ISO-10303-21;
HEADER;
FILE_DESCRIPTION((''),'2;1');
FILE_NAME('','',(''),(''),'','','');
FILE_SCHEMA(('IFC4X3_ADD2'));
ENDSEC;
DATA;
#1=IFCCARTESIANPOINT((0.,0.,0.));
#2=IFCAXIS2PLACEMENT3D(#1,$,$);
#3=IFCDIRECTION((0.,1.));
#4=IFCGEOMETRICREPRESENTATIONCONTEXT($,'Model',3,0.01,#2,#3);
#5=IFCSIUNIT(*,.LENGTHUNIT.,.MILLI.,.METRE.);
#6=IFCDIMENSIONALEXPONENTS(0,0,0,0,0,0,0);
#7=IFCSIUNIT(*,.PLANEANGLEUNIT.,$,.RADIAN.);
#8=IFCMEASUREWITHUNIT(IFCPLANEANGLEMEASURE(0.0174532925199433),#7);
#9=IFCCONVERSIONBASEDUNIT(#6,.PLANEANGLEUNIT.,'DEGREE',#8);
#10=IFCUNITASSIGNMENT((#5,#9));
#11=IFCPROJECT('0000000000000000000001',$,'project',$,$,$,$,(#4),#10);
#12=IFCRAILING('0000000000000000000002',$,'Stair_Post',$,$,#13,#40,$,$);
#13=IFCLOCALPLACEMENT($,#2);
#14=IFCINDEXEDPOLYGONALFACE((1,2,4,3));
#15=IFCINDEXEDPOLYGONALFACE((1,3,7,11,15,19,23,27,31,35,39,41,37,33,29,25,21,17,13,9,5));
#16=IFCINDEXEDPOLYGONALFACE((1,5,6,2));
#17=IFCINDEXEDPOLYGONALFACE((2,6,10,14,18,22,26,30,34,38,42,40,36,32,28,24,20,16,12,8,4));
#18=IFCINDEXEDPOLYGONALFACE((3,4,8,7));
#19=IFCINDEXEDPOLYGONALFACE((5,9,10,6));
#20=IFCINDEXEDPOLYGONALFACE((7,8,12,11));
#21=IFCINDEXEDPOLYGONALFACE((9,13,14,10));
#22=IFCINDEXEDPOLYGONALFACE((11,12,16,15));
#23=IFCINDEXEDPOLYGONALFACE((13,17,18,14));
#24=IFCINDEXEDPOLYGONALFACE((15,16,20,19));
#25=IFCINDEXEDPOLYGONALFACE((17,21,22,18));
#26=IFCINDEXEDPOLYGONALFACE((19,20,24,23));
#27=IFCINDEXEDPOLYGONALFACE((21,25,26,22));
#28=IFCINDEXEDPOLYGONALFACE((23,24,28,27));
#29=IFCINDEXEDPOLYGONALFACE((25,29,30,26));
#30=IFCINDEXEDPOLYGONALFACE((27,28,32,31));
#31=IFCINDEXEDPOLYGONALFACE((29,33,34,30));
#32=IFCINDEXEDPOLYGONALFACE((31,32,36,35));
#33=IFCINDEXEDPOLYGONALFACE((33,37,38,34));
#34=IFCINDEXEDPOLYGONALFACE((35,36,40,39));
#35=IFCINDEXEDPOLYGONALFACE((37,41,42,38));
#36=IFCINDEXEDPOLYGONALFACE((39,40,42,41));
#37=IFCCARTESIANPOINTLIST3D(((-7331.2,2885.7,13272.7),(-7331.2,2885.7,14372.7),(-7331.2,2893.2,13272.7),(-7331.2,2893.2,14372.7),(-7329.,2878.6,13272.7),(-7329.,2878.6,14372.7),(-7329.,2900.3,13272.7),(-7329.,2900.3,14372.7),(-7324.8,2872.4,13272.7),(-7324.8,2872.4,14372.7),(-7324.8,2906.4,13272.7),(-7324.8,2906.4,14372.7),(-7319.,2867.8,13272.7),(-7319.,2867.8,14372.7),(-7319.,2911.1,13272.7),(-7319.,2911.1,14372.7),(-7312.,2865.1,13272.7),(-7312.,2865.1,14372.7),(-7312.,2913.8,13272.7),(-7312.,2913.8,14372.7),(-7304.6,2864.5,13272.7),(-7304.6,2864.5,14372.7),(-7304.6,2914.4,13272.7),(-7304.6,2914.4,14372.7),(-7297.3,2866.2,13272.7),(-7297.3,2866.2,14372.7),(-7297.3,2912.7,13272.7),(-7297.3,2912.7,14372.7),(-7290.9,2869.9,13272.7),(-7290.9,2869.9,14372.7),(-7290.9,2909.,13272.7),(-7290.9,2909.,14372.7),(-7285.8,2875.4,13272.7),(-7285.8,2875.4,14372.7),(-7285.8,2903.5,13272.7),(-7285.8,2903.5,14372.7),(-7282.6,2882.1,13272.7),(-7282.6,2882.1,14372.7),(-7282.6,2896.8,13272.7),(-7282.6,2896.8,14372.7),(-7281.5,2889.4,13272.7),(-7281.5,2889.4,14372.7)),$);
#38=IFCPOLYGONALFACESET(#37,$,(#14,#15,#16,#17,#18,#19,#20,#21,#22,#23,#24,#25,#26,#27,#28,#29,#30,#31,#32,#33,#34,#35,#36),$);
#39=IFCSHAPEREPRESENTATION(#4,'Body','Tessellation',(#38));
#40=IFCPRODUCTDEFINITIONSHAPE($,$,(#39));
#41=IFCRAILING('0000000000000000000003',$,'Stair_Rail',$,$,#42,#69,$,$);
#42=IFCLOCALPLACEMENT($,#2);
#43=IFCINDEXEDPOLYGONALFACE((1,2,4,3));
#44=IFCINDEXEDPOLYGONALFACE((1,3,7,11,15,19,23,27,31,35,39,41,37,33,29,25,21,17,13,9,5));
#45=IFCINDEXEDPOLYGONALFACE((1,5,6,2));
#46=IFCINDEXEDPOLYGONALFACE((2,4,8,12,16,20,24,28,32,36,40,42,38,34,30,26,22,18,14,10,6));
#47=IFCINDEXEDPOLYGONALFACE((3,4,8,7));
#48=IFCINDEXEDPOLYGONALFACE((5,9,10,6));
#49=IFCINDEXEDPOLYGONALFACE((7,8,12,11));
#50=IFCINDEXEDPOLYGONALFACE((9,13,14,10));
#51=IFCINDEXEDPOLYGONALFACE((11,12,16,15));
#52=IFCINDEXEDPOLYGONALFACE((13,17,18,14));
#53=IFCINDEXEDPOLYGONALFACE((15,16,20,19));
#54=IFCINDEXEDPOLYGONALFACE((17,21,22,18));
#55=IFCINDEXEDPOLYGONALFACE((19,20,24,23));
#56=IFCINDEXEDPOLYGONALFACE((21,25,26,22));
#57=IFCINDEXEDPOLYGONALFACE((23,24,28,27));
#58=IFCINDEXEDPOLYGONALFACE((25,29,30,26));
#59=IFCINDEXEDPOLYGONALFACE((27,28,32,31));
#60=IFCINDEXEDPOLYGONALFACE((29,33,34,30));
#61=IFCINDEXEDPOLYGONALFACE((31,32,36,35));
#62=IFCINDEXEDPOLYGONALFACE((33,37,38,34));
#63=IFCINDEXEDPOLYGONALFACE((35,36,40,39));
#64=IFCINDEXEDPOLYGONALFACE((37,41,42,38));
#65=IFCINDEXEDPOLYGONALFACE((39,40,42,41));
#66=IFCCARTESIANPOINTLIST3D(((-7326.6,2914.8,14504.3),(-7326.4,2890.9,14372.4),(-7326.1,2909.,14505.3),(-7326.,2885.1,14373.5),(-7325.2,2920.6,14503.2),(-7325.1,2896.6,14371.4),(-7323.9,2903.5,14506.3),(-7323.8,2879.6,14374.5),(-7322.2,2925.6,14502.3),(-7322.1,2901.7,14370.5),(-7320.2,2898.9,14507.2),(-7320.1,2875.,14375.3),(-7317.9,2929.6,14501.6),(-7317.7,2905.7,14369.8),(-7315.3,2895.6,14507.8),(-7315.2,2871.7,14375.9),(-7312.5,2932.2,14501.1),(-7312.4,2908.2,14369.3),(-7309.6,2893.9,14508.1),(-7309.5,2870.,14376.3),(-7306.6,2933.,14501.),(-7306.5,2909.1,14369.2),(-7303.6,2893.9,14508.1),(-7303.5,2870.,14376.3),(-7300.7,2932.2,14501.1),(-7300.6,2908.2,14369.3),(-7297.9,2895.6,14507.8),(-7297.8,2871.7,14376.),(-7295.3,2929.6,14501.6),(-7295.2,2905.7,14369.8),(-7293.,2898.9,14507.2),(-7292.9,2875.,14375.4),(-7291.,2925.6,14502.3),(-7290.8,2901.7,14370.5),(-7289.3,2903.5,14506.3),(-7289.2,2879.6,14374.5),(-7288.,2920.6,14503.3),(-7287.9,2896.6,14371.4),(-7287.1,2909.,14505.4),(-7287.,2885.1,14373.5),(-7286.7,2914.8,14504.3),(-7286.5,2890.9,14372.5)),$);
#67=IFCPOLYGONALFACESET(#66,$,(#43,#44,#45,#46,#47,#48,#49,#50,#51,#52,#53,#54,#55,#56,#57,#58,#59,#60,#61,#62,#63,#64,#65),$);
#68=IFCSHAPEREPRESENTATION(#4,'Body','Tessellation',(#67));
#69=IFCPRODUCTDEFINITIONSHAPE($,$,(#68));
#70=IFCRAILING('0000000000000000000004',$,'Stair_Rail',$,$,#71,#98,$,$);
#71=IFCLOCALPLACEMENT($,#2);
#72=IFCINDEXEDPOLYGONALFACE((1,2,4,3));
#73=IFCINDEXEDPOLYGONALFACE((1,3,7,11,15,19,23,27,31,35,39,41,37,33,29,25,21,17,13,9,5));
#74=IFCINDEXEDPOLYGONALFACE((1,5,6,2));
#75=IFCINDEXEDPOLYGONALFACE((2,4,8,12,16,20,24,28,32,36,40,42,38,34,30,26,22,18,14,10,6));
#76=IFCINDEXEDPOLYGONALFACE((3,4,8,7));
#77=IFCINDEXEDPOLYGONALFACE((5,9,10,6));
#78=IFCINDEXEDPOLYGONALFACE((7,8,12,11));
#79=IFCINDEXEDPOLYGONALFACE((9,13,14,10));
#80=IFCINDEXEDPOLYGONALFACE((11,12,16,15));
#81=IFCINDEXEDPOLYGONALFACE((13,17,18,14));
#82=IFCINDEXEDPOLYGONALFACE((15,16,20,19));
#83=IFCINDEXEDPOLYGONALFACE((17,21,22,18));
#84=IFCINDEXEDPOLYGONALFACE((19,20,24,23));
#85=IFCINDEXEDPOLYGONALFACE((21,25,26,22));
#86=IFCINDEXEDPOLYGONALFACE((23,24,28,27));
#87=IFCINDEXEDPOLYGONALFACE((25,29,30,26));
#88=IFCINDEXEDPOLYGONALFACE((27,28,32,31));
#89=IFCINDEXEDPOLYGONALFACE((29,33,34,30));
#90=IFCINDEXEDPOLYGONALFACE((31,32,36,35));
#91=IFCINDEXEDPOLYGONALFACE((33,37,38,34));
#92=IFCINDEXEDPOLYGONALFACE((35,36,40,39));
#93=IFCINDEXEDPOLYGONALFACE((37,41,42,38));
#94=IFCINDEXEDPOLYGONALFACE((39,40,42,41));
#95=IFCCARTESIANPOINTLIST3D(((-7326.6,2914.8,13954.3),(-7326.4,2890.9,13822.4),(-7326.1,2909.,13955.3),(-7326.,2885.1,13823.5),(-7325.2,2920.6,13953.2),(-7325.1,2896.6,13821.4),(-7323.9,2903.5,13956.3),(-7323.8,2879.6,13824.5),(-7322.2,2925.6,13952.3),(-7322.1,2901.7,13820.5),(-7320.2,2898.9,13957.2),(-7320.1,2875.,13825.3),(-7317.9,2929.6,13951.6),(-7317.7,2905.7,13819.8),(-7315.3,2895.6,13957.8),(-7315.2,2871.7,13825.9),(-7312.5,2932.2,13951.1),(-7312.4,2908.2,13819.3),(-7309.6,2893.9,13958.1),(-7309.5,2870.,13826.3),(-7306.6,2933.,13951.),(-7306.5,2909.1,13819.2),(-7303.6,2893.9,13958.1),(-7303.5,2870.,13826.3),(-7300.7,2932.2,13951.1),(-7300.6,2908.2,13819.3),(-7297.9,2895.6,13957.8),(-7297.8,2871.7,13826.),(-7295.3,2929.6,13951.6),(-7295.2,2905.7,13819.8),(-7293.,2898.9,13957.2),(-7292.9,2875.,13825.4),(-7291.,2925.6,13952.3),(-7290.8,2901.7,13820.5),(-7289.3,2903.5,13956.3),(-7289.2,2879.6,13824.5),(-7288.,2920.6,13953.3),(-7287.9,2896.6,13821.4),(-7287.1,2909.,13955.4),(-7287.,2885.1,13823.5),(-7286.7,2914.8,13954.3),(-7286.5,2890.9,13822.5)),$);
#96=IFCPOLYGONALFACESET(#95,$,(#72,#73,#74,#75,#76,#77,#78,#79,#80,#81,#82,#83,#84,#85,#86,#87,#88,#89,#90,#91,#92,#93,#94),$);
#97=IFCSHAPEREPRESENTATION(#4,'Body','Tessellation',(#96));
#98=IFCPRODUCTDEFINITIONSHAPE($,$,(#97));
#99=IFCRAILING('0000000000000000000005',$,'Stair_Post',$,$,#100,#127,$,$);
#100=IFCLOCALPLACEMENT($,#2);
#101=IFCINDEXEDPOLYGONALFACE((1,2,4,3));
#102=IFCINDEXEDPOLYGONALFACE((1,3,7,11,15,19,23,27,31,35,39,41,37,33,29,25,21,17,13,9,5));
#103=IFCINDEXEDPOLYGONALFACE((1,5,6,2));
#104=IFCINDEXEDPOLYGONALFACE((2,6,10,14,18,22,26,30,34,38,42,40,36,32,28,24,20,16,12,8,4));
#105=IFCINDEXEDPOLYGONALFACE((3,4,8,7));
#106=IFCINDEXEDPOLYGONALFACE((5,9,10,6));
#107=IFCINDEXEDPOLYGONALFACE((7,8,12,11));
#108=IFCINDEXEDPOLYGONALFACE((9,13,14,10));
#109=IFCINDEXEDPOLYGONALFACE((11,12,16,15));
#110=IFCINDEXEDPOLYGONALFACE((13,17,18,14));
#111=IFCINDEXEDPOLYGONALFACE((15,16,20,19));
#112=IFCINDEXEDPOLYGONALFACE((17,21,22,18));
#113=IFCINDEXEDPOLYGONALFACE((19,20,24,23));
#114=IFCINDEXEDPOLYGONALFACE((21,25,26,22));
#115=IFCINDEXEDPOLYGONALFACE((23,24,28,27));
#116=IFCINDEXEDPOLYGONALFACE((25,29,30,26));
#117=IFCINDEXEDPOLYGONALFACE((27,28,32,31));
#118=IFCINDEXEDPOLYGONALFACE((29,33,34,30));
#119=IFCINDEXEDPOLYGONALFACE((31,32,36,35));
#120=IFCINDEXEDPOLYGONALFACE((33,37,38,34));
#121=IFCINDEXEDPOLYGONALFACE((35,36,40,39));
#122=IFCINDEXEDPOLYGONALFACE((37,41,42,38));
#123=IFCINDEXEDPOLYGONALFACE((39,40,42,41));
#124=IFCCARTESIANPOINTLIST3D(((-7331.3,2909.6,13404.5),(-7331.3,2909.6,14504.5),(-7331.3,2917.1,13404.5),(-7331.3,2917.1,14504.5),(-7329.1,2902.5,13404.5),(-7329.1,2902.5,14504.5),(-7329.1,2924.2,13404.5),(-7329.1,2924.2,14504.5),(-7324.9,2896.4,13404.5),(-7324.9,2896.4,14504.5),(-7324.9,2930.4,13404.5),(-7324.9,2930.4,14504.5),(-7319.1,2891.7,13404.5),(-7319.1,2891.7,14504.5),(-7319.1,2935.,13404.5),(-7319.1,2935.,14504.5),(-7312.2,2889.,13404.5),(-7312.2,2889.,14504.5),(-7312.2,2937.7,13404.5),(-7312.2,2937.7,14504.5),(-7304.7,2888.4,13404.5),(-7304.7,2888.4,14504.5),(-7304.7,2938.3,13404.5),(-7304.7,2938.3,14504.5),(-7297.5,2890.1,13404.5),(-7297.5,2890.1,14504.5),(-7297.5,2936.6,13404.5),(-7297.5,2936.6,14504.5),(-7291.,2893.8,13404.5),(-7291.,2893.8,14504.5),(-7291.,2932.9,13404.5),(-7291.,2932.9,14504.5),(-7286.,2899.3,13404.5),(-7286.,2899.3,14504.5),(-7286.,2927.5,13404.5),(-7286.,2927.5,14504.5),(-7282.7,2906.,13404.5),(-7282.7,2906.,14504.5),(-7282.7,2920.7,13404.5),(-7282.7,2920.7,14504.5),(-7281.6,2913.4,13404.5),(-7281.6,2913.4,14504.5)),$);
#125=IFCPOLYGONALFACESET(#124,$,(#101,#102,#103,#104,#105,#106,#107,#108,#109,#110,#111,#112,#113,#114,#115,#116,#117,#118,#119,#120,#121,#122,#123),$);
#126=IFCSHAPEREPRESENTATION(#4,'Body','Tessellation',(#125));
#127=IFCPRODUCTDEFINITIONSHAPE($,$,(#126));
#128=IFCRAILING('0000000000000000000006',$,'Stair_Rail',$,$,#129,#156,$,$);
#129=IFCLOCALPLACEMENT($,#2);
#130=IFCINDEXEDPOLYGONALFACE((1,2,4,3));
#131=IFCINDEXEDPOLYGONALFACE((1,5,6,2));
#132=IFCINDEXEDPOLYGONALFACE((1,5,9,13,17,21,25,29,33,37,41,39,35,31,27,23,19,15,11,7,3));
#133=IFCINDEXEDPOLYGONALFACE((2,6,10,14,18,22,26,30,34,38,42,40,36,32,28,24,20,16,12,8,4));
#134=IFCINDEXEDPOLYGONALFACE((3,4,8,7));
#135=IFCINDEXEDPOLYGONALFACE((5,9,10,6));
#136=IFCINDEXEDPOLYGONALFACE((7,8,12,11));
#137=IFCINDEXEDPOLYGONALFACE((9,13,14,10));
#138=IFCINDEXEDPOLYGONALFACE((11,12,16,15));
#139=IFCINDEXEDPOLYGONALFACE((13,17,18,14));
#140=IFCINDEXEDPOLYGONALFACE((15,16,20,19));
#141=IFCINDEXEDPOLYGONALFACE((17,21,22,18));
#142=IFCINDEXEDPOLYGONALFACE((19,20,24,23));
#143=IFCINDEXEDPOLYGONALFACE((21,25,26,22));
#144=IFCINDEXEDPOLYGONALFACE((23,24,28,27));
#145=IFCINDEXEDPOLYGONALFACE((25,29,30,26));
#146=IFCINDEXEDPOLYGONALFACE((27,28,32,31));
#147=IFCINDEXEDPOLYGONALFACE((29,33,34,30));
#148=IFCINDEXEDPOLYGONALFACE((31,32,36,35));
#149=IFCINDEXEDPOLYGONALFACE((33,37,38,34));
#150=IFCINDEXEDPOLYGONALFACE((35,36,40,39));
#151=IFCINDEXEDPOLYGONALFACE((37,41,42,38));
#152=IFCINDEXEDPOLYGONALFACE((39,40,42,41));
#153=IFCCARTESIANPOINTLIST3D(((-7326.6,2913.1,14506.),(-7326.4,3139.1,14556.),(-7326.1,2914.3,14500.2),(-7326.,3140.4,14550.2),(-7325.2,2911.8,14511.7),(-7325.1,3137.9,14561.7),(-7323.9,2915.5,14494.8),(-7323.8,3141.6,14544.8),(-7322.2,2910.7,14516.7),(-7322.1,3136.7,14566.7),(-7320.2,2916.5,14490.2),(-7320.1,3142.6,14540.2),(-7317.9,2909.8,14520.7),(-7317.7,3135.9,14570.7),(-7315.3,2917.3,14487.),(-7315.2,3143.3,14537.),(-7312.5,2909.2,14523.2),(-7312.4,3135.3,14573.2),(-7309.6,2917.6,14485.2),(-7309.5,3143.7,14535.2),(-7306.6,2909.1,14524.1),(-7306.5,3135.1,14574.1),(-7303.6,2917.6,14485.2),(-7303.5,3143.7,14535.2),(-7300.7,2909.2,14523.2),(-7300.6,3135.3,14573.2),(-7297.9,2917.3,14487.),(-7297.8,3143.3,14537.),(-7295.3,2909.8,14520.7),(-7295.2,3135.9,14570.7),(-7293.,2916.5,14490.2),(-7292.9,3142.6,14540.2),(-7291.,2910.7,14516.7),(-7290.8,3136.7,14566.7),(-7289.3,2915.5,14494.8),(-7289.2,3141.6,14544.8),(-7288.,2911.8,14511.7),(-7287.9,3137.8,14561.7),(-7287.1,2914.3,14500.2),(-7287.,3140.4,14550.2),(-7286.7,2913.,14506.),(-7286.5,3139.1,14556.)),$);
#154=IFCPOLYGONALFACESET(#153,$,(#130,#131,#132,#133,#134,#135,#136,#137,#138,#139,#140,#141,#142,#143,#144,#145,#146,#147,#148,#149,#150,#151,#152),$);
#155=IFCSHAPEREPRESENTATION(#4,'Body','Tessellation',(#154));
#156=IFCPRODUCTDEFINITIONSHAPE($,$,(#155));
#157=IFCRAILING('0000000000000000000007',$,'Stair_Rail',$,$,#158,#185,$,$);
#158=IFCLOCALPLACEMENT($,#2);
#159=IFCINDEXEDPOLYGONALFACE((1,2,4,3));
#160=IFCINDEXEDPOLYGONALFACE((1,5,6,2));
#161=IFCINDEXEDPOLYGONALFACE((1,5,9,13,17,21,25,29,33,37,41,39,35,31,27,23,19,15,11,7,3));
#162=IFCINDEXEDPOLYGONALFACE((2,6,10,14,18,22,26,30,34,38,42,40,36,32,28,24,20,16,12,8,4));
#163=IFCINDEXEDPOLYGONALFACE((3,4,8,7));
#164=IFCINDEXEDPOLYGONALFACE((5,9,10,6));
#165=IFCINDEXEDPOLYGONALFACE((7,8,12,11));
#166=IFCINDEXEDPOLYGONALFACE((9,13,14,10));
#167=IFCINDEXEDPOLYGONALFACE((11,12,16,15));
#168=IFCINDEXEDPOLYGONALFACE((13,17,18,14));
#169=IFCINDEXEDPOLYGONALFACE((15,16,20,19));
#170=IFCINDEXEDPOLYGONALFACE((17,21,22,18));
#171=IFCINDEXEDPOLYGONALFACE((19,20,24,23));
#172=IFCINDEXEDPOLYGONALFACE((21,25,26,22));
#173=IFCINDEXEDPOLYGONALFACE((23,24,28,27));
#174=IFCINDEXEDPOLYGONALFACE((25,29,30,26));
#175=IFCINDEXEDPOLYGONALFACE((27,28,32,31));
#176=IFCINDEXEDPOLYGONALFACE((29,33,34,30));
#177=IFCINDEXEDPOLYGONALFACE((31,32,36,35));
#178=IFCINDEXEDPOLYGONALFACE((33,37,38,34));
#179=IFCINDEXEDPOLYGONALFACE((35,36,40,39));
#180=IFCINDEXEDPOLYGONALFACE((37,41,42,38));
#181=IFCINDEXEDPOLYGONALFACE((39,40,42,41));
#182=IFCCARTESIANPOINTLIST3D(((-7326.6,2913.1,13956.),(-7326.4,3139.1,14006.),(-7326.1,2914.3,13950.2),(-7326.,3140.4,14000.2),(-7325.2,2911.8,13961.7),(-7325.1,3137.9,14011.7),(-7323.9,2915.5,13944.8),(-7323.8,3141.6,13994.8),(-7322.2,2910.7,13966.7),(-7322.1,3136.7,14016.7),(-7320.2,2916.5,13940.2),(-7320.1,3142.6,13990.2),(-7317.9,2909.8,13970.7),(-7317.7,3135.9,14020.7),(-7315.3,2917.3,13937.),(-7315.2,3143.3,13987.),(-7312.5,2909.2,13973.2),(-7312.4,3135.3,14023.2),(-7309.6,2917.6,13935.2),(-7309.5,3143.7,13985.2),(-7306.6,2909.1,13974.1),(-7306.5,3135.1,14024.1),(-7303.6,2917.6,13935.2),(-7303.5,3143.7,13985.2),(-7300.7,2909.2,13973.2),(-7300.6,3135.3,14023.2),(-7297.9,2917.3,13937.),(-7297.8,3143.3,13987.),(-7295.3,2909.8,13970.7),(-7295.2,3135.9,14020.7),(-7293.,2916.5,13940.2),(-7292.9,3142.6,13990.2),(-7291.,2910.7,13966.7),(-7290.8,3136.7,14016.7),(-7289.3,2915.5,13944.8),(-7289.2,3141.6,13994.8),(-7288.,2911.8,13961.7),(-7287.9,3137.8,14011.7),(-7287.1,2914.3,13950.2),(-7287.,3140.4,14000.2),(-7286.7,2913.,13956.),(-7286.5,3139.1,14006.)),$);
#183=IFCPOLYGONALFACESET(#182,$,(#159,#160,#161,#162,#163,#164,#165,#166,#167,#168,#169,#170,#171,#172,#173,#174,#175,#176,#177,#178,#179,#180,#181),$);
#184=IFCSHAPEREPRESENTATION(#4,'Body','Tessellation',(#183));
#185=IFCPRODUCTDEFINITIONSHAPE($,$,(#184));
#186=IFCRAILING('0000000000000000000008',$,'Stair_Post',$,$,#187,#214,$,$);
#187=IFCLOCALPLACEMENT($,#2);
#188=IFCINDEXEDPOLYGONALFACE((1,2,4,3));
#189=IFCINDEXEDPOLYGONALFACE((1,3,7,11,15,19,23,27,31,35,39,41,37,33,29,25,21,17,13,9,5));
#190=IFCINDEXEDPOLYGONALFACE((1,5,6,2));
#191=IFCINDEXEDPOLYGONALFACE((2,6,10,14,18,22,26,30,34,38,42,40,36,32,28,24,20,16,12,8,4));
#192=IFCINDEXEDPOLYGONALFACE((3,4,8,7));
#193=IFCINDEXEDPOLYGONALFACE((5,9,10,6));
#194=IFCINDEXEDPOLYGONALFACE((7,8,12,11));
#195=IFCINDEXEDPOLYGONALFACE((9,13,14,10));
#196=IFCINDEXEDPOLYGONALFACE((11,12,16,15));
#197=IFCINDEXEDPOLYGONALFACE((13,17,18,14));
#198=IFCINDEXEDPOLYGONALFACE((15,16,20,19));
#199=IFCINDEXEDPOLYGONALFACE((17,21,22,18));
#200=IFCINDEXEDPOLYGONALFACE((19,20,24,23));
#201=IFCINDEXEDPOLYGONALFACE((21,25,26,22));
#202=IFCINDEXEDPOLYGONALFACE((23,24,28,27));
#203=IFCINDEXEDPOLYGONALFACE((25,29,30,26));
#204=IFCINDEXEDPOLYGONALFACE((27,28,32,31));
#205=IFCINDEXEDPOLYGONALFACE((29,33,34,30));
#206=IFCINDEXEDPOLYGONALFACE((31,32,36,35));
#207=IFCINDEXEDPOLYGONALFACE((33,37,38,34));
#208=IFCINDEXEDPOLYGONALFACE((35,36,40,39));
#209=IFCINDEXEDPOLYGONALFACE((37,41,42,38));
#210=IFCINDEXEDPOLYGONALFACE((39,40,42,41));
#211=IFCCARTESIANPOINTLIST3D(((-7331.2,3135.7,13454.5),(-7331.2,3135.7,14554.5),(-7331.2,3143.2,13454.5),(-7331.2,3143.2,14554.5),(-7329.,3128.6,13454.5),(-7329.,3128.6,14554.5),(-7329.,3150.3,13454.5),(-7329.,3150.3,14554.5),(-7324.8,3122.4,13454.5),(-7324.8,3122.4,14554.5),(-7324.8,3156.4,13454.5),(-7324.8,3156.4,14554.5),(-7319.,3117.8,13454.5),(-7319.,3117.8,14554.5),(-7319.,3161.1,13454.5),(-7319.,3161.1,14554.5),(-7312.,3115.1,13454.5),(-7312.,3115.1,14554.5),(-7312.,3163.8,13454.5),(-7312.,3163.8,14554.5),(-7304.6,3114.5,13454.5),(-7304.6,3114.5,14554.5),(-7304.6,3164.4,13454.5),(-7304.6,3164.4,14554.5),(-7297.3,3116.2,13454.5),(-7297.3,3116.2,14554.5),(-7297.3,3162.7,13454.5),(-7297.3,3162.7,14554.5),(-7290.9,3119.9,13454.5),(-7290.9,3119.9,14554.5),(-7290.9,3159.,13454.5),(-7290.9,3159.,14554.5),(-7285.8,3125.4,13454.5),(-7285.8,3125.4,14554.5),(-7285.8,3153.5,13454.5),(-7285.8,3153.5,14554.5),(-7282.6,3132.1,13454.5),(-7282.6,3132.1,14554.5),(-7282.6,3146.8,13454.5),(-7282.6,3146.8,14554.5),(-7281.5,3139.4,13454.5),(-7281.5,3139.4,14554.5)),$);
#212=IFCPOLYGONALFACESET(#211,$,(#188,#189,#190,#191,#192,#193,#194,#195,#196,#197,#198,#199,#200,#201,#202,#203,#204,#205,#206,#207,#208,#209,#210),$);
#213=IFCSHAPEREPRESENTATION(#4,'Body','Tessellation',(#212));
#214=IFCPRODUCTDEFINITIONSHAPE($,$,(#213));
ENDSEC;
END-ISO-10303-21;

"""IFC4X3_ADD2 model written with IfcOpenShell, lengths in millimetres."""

from ifc_helpers import new_model, entity, si_unit, converted_unit, direction, frame, origin, context, project, circle, extrude, element, save


model = new_model("IFC4X3_ADD2")

# Units and contexts
model_context = context("Model", 3, precision=0.01, world=origin(), true_north=direction((0.0, 1.0)))
ifc_project = project(units=[si_unit("LENGTHUNIT", "METRE", prefix="MILLI"), converted_unit("PLANEANGLEUNIT", "DEGREE", entity("IfcPlaneAngleMeasure", 0.0174532925199433), si_unit("PLANEANGLEUNIT", "RADIAN"), dimensions=[0, 0, 0, 0, 0, 0, 0])], contexts=[model_context])

# Railings
element("IfcRailing", 1, Name="Stair_Post", context=model_context, shape_type="SweptSolid", body=[
    extrude(circle(Radius=25.0), frame((-7306.5, 2889.4, 13272.7)), (0.0, 0.0, 1.0), 1100.0),
])
element("IfcRailing", 2, Name="Stair_Rail", context=model_context, shape_type="SweptSolid", body=[
    entity("IfcSweptDiskSolid", entity("IfcPolyline", [entity("IfcCartesianPoint", [-7306.5, 2889.4, 14372.7]), entity("IfcCartesianPoint", [-7306.6, 2913.4, 14504.5])]), 20.0),
])
element("IfcRailing", 3, Name="Stair_Rail", context=model_context, shape_type="SweptSolid", body=[
    entity("IfcSweptDiskSolid", entity("IfcPolyline", [entity("IfcCartesianPoint", [-7306.5, 2889.4, 13822.7]), entity("IfcCartesianPoint", [-7306.6, 2913.4, 13954.5])]), 20.0),
])
element("IfcRailing", 4, Name="Stair_Post", context=model_context, shape_type="SweptSolid", body=[
    extrude(circle(Radius=25.0), frame((-7306.6, 2913.4, 13404.5)), (0.0, 0.0, 1.0), 1100.0),
])
element("IfcRailing", 5, Name="Stair_Rail", context=model_context, shape_type="SweptSolid", body=[
    entity("IfcSweptDiskSolid", entity("IfcPolyline", [entity("IfcCartesianPoint", [-7306.6, 2913.4, 14504.5]), entity("IfcCartesianPoint", [-7306.5, 3139.4, 14554.5])]), 20.0),
])
element("IfcRailing", 6, Name="Stair_Rail", context=model_context, shape_type="SweptSolid", body=[
    entity("IfcSweptDiskSolid", entity("IfcPolyline", [entity("IfcCartesianPoint", [-7306.6, 2913.4, 13954.5]), entity("IfcCartesianPoint", [-7306.5, 3139.4, 14004.5])]), 20.0),
])
element("IfcRailing", 7, Name="Stair_Post", context=model_context, shape_type="SweptSolid", body=[
    extrude(circle(Radius=25.0), frame((-7306.5, 3139.4, 13454.5)), (0.0, 0.0, 1.0), 1100.0),
])

save(model, "model.ifc")
